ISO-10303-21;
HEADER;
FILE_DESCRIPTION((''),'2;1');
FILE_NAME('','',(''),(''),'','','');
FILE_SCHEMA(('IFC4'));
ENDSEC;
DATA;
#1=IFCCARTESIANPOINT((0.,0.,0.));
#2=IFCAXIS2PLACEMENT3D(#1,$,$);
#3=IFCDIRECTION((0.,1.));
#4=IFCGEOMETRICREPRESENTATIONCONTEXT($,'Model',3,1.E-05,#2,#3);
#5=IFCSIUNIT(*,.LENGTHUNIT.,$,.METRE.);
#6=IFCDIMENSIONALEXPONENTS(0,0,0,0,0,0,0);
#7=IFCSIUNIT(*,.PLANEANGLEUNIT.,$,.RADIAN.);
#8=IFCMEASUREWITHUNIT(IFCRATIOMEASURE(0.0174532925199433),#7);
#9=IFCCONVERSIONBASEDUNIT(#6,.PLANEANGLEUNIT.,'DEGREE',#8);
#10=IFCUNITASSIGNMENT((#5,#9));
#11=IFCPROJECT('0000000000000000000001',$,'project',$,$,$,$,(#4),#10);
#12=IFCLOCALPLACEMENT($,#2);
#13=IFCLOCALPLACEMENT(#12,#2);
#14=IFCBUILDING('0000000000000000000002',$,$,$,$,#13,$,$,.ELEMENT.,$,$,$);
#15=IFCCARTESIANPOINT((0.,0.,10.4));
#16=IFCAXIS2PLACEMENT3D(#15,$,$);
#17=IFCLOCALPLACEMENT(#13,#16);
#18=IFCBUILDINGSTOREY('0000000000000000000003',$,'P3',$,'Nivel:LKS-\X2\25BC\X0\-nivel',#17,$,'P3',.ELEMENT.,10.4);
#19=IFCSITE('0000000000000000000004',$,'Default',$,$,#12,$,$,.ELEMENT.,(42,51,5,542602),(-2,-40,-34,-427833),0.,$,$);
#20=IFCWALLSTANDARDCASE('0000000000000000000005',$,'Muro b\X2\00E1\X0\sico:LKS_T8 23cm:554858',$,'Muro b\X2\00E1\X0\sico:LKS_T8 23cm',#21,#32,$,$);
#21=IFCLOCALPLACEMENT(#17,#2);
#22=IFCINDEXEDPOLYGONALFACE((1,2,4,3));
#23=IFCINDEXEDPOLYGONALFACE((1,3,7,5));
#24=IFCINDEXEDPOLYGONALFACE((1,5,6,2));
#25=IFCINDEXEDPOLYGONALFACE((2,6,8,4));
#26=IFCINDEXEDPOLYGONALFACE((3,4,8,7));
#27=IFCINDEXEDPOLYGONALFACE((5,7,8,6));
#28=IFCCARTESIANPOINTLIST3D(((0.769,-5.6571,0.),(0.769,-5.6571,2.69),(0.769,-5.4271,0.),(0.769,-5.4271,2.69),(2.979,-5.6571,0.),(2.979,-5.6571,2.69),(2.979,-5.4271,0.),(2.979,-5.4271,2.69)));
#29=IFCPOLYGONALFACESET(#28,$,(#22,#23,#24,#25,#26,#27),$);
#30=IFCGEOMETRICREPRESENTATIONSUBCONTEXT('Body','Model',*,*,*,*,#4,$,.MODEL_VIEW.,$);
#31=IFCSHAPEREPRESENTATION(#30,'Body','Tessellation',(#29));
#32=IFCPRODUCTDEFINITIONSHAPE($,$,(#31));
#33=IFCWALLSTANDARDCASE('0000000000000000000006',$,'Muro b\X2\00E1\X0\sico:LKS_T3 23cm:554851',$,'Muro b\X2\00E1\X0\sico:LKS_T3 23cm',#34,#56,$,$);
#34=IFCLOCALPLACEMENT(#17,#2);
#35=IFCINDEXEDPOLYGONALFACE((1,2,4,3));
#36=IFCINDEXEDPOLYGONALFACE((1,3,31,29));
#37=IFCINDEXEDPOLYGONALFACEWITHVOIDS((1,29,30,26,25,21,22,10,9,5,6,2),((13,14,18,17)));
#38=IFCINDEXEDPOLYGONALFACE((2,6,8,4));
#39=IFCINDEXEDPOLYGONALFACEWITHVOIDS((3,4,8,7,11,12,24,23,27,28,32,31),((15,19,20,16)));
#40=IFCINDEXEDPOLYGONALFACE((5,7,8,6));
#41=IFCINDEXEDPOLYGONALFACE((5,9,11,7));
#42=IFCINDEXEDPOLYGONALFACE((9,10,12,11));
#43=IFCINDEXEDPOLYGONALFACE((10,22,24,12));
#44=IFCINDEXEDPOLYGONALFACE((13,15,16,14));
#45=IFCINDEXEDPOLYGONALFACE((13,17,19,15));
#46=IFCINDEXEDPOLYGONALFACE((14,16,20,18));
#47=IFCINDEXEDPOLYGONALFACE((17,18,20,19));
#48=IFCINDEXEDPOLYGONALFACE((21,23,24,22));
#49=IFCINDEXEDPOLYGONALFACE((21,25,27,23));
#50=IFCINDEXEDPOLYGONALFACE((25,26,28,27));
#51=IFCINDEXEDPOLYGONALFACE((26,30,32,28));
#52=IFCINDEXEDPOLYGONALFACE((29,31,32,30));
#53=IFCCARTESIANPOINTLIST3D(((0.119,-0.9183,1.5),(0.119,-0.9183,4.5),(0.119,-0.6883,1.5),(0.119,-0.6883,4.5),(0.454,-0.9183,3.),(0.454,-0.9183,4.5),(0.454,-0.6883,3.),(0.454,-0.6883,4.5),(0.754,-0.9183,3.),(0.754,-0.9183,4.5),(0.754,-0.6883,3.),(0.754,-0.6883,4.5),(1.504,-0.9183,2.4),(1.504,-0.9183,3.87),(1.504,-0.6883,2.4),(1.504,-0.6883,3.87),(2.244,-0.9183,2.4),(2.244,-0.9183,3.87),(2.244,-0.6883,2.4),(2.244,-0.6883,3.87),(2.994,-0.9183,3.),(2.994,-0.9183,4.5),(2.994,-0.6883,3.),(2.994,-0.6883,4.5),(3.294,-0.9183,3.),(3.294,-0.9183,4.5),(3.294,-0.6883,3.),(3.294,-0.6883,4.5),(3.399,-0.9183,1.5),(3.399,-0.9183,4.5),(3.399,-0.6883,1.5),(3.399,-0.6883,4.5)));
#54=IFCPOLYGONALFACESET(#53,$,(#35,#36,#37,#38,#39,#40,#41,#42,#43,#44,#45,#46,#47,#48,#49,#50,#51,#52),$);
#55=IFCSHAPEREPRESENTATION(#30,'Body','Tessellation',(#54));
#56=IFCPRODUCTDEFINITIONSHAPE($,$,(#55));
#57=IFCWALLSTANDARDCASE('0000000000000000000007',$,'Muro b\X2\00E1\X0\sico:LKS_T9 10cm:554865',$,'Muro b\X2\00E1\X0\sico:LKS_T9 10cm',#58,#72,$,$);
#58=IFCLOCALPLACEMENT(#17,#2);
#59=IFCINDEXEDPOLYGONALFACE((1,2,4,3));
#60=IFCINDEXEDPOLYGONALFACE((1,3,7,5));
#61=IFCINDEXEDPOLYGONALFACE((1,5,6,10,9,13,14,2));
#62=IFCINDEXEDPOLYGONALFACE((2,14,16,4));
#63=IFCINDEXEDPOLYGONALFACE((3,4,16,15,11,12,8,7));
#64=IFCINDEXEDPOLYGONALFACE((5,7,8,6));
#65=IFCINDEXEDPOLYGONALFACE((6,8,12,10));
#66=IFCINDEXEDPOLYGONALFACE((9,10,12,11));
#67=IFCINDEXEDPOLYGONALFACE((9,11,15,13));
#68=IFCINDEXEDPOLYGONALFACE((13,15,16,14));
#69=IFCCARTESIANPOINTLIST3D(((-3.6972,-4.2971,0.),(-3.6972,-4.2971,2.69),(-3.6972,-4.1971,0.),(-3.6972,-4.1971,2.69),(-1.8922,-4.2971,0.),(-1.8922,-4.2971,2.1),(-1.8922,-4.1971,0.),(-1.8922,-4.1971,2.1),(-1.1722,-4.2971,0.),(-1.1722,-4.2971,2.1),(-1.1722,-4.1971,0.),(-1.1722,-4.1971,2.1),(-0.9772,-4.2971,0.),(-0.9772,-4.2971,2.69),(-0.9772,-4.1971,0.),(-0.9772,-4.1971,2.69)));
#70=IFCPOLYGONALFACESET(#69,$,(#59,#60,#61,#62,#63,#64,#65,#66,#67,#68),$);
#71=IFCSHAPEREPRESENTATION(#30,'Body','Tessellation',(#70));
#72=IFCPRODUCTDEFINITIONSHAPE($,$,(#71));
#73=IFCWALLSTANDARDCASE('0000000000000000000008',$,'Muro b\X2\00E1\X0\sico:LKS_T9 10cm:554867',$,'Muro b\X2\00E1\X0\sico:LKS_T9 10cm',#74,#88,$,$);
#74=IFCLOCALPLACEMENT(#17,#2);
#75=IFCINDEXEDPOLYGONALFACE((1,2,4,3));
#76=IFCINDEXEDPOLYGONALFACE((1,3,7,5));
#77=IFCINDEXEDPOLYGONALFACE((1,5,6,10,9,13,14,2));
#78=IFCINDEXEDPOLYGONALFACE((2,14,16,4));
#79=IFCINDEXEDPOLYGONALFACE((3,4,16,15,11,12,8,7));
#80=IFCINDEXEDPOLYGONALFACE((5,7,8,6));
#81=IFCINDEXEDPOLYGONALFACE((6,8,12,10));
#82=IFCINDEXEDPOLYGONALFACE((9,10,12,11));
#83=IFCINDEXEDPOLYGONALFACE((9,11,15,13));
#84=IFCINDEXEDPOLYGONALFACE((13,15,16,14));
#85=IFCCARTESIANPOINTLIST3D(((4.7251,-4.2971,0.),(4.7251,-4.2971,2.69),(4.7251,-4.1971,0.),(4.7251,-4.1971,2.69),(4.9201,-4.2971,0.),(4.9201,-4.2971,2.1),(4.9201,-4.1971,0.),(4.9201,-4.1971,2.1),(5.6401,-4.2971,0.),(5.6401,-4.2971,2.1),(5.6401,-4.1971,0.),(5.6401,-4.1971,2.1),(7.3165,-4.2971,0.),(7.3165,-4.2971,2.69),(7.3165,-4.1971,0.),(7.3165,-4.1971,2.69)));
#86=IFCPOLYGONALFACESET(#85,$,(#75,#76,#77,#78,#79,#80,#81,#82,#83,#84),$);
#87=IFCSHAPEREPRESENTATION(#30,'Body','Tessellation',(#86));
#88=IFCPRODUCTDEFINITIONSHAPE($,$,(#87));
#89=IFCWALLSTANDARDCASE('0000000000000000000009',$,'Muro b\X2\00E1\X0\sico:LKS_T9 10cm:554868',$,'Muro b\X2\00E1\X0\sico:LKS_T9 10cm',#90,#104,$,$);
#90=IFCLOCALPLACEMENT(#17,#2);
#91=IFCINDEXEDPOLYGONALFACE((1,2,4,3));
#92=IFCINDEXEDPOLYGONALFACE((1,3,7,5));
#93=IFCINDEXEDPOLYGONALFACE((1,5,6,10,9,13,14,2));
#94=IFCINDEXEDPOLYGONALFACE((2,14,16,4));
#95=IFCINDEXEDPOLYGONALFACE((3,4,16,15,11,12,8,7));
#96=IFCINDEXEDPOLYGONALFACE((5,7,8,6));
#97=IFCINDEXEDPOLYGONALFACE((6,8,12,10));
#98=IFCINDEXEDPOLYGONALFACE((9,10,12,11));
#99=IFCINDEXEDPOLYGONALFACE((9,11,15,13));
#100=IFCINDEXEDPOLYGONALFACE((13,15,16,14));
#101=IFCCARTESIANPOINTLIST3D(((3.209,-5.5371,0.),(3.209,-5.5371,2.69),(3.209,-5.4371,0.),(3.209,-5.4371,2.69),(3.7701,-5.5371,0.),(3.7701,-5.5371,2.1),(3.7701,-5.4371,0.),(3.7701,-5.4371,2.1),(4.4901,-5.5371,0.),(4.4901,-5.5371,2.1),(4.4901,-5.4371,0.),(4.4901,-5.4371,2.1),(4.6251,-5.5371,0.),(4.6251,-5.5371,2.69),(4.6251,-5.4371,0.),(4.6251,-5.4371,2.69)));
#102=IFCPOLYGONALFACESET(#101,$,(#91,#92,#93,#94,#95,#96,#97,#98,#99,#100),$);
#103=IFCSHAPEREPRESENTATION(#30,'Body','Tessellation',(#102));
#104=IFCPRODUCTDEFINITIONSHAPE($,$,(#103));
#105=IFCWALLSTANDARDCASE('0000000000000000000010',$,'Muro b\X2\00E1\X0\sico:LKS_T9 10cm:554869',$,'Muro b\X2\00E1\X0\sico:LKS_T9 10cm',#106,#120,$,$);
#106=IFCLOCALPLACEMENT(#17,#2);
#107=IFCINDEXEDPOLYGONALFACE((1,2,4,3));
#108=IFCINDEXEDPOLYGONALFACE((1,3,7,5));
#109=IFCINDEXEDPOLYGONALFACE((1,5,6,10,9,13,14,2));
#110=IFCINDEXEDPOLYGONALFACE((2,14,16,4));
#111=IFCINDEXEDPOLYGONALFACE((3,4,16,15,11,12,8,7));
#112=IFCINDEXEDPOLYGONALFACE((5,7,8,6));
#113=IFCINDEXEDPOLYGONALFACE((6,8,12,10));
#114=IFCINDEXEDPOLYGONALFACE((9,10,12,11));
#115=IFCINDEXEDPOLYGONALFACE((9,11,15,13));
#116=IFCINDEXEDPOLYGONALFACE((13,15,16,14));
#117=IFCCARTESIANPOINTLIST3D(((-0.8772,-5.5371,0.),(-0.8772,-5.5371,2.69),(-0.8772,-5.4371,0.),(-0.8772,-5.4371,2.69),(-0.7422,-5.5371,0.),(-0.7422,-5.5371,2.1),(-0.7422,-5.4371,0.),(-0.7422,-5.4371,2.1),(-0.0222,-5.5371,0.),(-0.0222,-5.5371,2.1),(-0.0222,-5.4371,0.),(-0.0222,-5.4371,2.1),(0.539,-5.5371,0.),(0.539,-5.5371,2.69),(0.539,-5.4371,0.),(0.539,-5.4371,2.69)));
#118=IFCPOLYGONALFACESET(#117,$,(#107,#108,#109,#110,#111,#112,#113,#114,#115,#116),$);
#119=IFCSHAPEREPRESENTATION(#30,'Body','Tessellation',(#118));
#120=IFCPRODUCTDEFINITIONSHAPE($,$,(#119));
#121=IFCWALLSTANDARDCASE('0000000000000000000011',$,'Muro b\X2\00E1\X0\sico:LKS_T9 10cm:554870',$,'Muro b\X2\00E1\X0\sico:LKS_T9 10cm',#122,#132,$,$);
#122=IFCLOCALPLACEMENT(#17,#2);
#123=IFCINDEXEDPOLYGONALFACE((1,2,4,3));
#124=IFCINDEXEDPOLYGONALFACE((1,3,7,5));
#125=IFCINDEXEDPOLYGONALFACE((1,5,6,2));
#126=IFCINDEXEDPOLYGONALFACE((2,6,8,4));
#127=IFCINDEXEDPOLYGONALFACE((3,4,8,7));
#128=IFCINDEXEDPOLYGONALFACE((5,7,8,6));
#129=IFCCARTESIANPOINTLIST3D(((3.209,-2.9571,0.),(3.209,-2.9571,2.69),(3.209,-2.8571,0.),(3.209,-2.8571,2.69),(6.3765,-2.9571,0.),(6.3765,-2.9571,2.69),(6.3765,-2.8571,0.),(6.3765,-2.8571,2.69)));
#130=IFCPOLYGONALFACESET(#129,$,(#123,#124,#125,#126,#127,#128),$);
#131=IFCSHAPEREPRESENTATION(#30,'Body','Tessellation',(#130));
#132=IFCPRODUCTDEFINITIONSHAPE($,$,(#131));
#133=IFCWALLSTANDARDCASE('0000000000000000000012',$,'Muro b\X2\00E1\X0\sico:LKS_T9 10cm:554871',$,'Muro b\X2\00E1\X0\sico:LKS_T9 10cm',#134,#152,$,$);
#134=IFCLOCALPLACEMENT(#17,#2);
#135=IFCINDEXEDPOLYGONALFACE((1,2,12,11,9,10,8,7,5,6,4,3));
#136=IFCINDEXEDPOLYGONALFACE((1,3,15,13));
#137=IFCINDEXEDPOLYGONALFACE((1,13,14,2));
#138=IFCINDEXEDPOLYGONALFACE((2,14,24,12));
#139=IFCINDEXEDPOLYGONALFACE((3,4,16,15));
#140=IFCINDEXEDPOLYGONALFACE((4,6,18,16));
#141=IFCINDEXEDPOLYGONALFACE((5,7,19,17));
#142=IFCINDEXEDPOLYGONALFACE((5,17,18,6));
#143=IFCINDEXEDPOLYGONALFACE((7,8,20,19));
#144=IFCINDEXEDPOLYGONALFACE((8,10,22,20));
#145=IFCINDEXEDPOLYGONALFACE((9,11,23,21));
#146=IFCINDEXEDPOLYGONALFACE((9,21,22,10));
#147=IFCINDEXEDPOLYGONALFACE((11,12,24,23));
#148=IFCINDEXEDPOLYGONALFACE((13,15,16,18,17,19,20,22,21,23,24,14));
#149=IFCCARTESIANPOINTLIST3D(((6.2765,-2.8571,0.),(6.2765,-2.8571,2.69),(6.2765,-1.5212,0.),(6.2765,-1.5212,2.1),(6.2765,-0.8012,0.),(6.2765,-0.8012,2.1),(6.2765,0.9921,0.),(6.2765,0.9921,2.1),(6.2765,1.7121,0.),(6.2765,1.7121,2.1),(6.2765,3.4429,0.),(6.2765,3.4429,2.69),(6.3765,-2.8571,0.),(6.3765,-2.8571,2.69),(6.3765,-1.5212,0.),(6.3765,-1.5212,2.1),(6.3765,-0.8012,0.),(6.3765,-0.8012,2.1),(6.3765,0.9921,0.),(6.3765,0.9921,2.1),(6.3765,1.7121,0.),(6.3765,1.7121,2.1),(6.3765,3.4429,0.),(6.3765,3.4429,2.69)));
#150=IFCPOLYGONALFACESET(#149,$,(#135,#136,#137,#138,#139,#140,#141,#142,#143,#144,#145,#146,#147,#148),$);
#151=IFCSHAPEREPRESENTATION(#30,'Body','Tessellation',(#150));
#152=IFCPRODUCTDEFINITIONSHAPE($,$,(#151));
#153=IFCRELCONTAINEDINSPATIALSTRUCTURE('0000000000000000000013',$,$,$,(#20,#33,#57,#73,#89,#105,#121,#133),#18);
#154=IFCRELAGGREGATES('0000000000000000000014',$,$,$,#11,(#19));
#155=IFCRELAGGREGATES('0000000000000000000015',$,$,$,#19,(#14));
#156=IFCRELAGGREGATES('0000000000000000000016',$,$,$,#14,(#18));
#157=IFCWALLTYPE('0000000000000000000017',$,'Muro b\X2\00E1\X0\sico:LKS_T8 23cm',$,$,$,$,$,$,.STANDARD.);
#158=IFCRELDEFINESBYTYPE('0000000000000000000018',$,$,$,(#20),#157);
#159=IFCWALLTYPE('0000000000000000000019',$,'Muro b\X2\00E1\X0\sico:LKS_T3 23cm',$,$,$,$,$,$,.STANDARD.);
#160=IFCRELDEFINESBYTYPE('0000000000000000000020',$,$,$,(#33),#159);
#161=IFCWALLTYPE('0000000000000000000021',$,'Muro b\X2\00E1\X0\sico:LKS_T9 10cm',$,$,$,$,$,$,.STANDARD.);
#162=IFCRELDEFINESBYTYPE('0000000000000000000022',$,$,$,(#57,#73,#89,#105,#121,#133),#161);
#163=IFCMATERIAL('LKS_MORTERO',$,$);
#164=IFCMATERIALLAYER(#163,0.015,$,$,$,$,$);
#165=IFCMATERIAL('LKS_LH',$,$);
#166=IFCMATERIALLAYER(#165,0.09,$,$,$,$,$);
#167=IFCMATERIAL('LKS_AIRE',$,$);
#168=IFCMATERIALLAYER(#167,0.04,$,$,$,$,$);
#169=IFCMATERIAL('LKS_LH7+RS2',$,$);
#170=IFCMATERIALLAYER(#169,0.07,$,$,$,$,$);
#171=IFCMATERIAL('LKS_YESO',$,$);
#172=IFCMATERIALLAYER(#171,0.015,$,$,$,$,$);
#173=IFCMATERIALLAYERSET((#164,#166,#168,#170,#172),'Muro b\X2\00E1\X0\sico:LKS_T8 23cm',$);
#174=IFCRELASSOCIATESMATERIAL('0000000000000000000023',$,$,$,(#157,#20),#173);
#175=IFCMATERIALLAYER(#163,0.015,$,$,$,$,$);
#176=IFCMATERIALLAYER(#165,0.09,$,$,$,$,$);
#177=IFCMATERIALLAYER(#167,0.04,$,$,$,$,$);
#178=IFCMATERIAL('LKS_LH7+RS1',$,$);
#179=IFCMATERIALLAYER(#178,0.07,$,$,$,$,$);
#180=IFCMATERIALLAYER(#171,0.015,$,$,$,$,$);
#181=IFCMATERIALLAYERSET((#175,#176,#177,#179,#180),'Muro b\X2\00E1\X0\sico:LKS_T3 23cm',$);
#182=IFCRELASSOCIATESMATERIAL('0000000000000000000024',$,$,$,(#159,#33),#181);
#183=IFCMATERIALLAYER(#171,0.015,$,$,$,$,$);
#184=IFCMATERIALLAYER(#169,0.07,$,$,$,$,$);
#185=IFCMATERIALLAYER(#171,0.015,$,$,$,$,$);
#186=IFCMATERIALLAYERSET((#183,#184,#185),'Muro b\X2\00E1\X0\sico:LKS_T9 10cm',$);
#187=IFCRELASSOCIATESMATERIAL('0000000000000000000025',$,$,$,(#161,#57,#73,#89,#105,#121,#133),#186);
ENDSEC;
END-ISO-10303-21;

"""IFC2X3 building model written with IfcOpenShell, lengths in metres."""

from ifc_helpers import new_model, entity, si_unit, converted_unit, direction, frame, frame_2d, origin, place, context, subcontext, project, spatial, polyline, rectangle, extrude, clip, bounded_halfspace, material, layer, layer_set, layer_usage, type_object, element, save


model = new_model("IFC2X3")

# Units and contexts
model_context = context("Model", 3, precision=1e-05, world=origin(), true_north=direction((0.0, 1.0)))
body_context = subcontext(model_context, "Body", "Model", "MODEL_VIEW")
ifc_project = project(units=[si_unit("LENGTHUNIT", "METRE"), converted_unit("PLANEANGLEUNIT", "DEGREE", entity("IfcRatioMeasure", 0.0174532925199433), si_unit("PLANEANGLEUNIT", "RADIAN"), dimensions=[0, 0, 0, 0, 0, 0, 0])], contexts=[model_context])

# Site, building, storey
site_placement = place(None, origin())
site = spatial("IfcSite", under=ifc_project, at=site_placement, Name="Default", CompositionType="ELEMENT", RefLatitude=(42, 51, 5, 542602), RefLongitude=(-2, -40, -34, -427833), RefElevation=0.0)
building_placement = place(site_placement, origin())
building = spatial("IfcBuilding", under=site, at=building_placement, CompositionType="ELEMENT")
storey_placement = place(building_placement, frame((0.0, 0.0, 10.4)))
storey = spatial("IfcBuildingStorey", under=building, at=storey_placement, Name="P3", ObjectType="Nivel:LKS-▼-nivel", LongName="P3", CompositionType="ELEMENT", Elevation=10.4)

# Wall
ifc_material_1 = material(Name="LKS_MORTERO")
ifc_layer_1 = layer(ifc_material_1, 0.015)
ifc_material_2 = material(Name="LKS_LH")
ifc_layer_2 = layer(ifc_material_2, 0.09)
ifc_material_3 = material(Name="LKS_AIRE")
ifc_layer_3 = layer(ifc_material_3, 0.04)
ifc_material_4 = material(Name="LKS_LH7+RS2")
ifc_layer_4 = layer(ifc_material_4, 0.07)
ifc_material_5 = material(Name="LKS_YESO")
ifc_layer_5 = layer(ifc_material_5, 0.015)
ifc_layer_set_1 = layer_set([ifc_layer_1, ifc_layer_2, ifc_layer_3, ifc_layer_4, ifc_layer_5], Name="Muro básico:LKS_T8 23cm")
ifc_layer_usage_1 = layer_usage(ifc_layer_set_1, "AXIS2", "POSITIVE", -0.115)
wall_type_1 = type_object("IfcWallType", Name="Muro básico:LKS_T8 23cm", PredefinedType="STANDARD", material=ifc_layer_set_1)
wall_1_placement = place(storey_placement, frame((2.979, -5.5421, 0.0), z_axis=(0.0, 0.0, 1.0), x_axis=(-1.0, 0.0, 0.0)))
element("IfcWallStandardCase", 1, at=wall_1_placement, inside=storey, type_object=wall_type_1, material=ifc_layer_usage_1, Name="Muro básico:LKS_T8 23cm:554858", ObjectType="Muro básico:LKS_T8 23cm", context=body_context, shape_type="SweptSolid", body=[
    extrude(rectangle(XDim=2.21, YDim=0.23, at=frame_2d((1.105, 0.0), x_axis=(-1.0, 0.0))), origin(), (0.0, 0.0, 1.0), 2.69),
])

# Walls, openings
ifc_layer_6 = layer(ifc_material_1, 0.015)
ifc_layer_7 = layer(ifc_material_2, 0.09)
ifc_layer_8 = layer(ifc_material_3, 0.04)
ifc_material_6 = material(Name="LKS_LH7+RS1")
ifc_layer_9 = layer(ifc_material_6, 0.07)
ifc_layer_10 = layer(ifc_material_5, 0.015)
ifc_layer_set_2 = layer_set([ifc_layer_6, ifc_layer_7, ifc_layer_8, ifc_layer_9, ifc_layer_10], Name="Muro básico:LKS_T3 23cm")
ifc_layer_usage_2 = layer_usage(ifc_layer_set_2, "AXIS2", "NEGATIVE", 0.115)
wall_type_2 = type_object("IfcWallType", Name="Muro básico:LKS_T3 23cm", PredefinedType="STANDARD", material=ifc_layer_set_2)
wall_2_placement = place(storey_placement, frame((3.629, -0.8033, 1.5), z_axis=(0.0, 0.0, 1.0), x_axis=(-1.0, 0.0, 0.0)))
wall_2 = element("IfcWallStandardCase", 2, at=wall_2_placement, inside=storey, type_object=wall_type_2, material=ifc_layer_usage_2, Name="Muro básico:LKS_T3 23cm:554851", ObjectType="Muro básico:LKS_T3 23cm", context=body_context, shape_type="Clipping", body=[
    clip(clip(extrude(rectangle(XDim=3.28, YDim=0.23, at=frame_2d((1.87, 0.0), x_axis=(-1.0, 0.0))), origin(), (0.0, 0.0, 1.0), 3.0), bounded_halfspace(frame((0.635, -0.115, 1.5), z_axis=(0.0, 0.0, -1.0), x_axis=(-1.0, 0.0, 0.0)), True, frame((0.635, -0.115, 1.5), z_axis=(0.0, 0.0, -1.0), x_axis=(-1.0, 0.0, 0.0)), polyline([(0.0, 0.0), (0.3, 0.0), (0.3, 0.23), (0.0, 0.23), (0.0, 0.0)]))), bounded_halfspace(frame((3.175, -0.115, 1.5), z_axis=(0.0, 0.0, -1.0), x_axis=(-1.0, 0.0, 0.0)), True, frame((3.175, -0.115, 1.5), z_axis=(0.0, 0.0, -1.0), x_axis=(-1.0, 0.0, 0.0)), polyline([(0.0, 0.0), (0.3, 0.0), (0.3, 0.23), (0.0, 0.23), (0.0, 0.0)]))),
])
opening_1_placement = place(wall_2_placement, frame((2.125, 0.115, 0.9)))
element("IfcOpeningElement", 3, at=opening_1_placement, cuts=wall_2, ObjectType="Opening", context=body_context, shape_type="SweptSolid", body=[
    extrude(rectangle(XDim=1.47, YDim=0.74, at=frame_2d((0.735, 0.37), x_axis=(1.0, 0.0))), frame((0.0, 0.0, 0.0), z_axis=(0.0, -1.0, 0.0), x_axis=(0.0, 0.0, 1.0)), (0.0, 0.0, 1.0), 0.23),
])
ifc_layer_11 = layer(ifc_material_5, 0.015)
ifc_layer_12 = layer(ifc_material_4, 0.07)
ifc_layer_13 = layer(ifc_material_5, 0.015)
ifc_layer_set_3 = layer_set([ifc_layer_11, ifc_layer_12, ifc_layer_13], Name="Muro básico:LKS_T9 10cm")
ifc_layer_usage_3 = layer_usage(ifc_layer_set_3, "AXIS2", "POSITIVE", -0.05)
wall_type_3 = type_object("IfcWallType", Name="Muro básico:LKS_T9 10cm", PredefinedType="STANDARD", material=ifc_layer_set_3)
wall_3_placement = place(storey_placement, frame((-0.9772, -4.2471, 0.0), z_axis=(0.0, 0.0, 1.0), x_axis=(-1.0, 0.0, 0.0)))
wall_3 = element("IfcWallStandardCase", 4, at=wall_3_placement, inside=storey, type_object=wall_type_3, material=ifc_layer_usage_3, Name="Muro básico:LKS_T9 10cm:554865", ObjectType="Muro básico:LKS_T9 10cm", context=body_context, shape_type="SweptSolid", body=[
    extrude(rectangle(XDim=2.72, YDim=0.1, at=frame_2d((1.36, 0.0), x_axis=(-1.0, 0.0))), origin(), (0.0, 0.0, 1.0), 2.69),
])
opening_2_placement = place(wall_3_placement, frame((0.195, -0.05, 0.0)))
element("IfcOpeningElement", 5, at=opening_2_placement, cuts=wall_3, ObjectType="Opening", context=body_context, shape_type="SweptSolid", body=[
    extrude(rectangle(XDim=2.1, YDim=0.72, at=frame_2d((1.05, 0.36), x_axis=(1.0, 0.0))), frame((0.0, 0.0, 0.0), z_axis=(0.0, 1.0, 0.0), x_axis=(0.0, 0.0, 1.0)), (0.0, 0.0, 1.0), 0.1),
])
ifc_layer_usage_4 = layer_usage(ifc_layer_set_3, "AXIS2", "NEGATIVE", 0.05)
wall_4_placement = place(storey_placement, frame((4.7251, -4.2471, 0.0)))
wall_4 = element("IfcWallStandardCase", 6, at=wall_4_placement, inside=storey, type_object=wall_type_3, material=ifc_layer_usage_4, Name="Muro básico:LKS_T9 10cm:554867", ObjectType="Muro básico:LKS_T9 10cm", context=body_context, shape_type="Clipping", body=[
    clip(extrude(rectangle(XDim=2.5915, YDim=0.1, at=frame_2d((1.2957, 0.0), x_axis=(-1.0, 0.0))), origin(), (0.0, 0.0, 1.0), 2.69), bounded_halfspace(frame((2.5915, -0.05, 2.69), z_axis=(-1.0, 0.0, 0.0), x_axis=(0.0, 0.0, -1.0)), True, frame((2.5915, -0.05, 2.69), z_axis=(-1.0, 0.0, 0.0), x_axis=(0.0, 0.0, -1.0)), polyline([(0.0, 0.0), (0.0, -0.1), (2.69, -0.1), (2.69, 0.0), (0.0, 0.0)]))),
])
opening_3_placement = place(wall_4_placement, frame((0.915, 0.05, 0.0)))
element("IfcOpeningElement", 7, at=opening_3_placement, cuts=wall_4, ObjectType="Opening", context=body_context, shape_type="SweptSolid", body=[
    extrude(rectangle(XDim=2.1, YDim=0.72, at=frame_2d((1.05, 0.36), x_axis=(1.0, 0.0))), frame((0.0, 0.0, 0.0), z_axis=(0.0, -1.0, 0.0), x_axis=(0.0, 0.0, 1.0)), (0.0, 0.0, 1.0), 0.1),
])
ifc_layer_usage_5 = layer_usage(ifc_layer_set_3, "AXIS2", "POSITIVE", -0.05)
wall_5_placement = place(storey_placement, frame((3.209, -5.4871, 0.0)))
wall_5 = element("IfcWallStandardCase", 8, at=wall_5_placement, inside=storey, type_object=wall_type_3, material=ifc_layer_usage_5, Name="Muro básico:LKS_T9 10cm:554868", ObjectType="Muro básico:LKS_T9 10cm", context=body_context, shape_type="SweptSolid", body=[
    extrude(rectangle(XDim=1.4161, YDim=0.1, at=frame_2d((0.7081, 0.0), x_axis=(-1.0, 0.0))), origin(), (0.0, 0.0, 1.0), 2.69),
])
opening_4_placement = place(wall_5_placement, frame((1.2811, 0.05, 0.0)))
element("IfcOpeningElement", 9, at=opening_4_placement, cuts=wall_5, ObjectType="Opening", context=body_context, shape_type="SweptSolid", body=[
    extrude(rectangle(XDim=2.1, YDim=0.72, at=frame_2d((1.05, 0.36), x_axis=(1.0, 0.0))), frame((0.0, 0.0, 0.0), z_axis=(0.0, -1.0, 0.0), x_axis=(0.0, 0.0, 1.0)), (0.0, 0.0, 1.0), 0.1),
])
ifc_layer_usage_6 = layer_usage(ifc_layer_set_3, "AXIS2", "NEGATIVE", 0.05)
wall_6_placement = place(storey_placement, frame((0.539, -5.4871, 0.0), z_axis=(0.0, 0.0, 1.0), x_axis=(-1.0, 0.0, 0.0)))
wall_6 = element("IfcWallStandardCase", 10, at=wall_6_placement, inside=storey, type_object=wall_type_3, material=ifc_layer_usage_6, Name="Muro básico:LKS_T9 10cm:554869", ObjectType="Muro básico:LKS_T9 10cm", context=body_context, shape_type="SweptSolid", body=[
    extrude(rectangle(XDim=1.4161, YDim=0.1, at=frame_2d((0.7081, 0.0), x_axis=(-1.0, 0.0))), origin(), (0.0, 0.0, 1.0), 2.69),
])
opening_5_placement = place(wall_6_placement, frame((0.5611, -0.05, 0.0)))
element("IfcOpeningElement", 11, at=opening_5_placement, cuts=wall_6, ObjectType="Opening", context=body_context, shape_type="SweptSolid", body=[
    extrude(rectangle(XDim=2.1, YDim=0.72, at=frame_2d((1.05, 0.36), x_axis=(1.0, 0.0))), frame((0.0, 0.0, 0.0), z_axis=(0.0, 1.0, 0.0), x_axis=(0.0, 0.0, 1.0)), (0.0, 0.0, 1.0), 0.1),
])

# Wall
ifc_layer_usage_7 = layer_usage(ifc_layer_set_3, "AXIS2", "NEGATIVE", 0.05)
wall_7_placement = place(storey_placement, frame((3.209, -2.9071, 0.0)))
element("IfcWallStandardCase", 12, at=wall_7_placement, inside=storey, type_object=wall_type_3, material=ifc_layer_usage_7, Name="Muro básico:LKS_T9 10cm:554870", ObjectType="Muro básico:LKS_T9 10cm", context=body_context, shape_type="SweptSolid", body=[
    extrude(rectangle(XDim=3.1676, YDim=0.1, at=frame_2d((1.5838, 0.0), x_axis=(-1.0, 0.0))), origin(), (0.0, 0.0, 1.0), 2.69),
])

# Wall, openings
ifc_layer_usage_8 = layer_usage(ifc_layer_set_3, "AXIS2", "NEGATIVE", 0.05)
wall_8_placement = place(storey_placement, frame((6.3265, -2.8571, 0.0), z_axis=(0.0, 0.0, 1.0), x_axis=(0.0, 1.0, 0.0)))
wall_8 = element("IfcWallStandardCase", 13, at=wall_8_placement, inside=storey, type_object=wall_type_3, material=ifc_layer_usage_8, Name="Muro básico:LKS_T9 10cm:554871", ObjectType="Muro básico:LKS_T9 10cm", context=body_context, shape_type="SweptSolid", body=[
    extrude(rectangle(XDim=6.3, YDim=0.1, at=frame_2d((3.15, 0.0), x_axis=(-1.0, 0.0))), origin(), (0.0, 0.0, 1.0), 2.69),
])
opening_6_placement = place(wall_8_placement, frame((1.3359, -0.05, 0.0)))
element("IfcOpeningElement", 14, at=opening_6_placement, cuts=wall_8, ObjectType="Opening", context=body_context, shape_type="SweptSolid", body=[
    extrude(rectangle(XDim=2.1, YDim=0.72, at=frame_2d((1.05, 0.36), x_axis=(1.0, 0.0))), frame((0.0, 0.0, 0.0), z_axis=(0.0, 1.0, 0.0), x_axis=(0.0, 0.0, 1.0)), (0.0, 0.0, 1.0), 0.1),
])
opening_7_placement = place(wall_8_placement, frame((3.8492, -0.05, 0.0)))
element("IfcOpeningElement", 15, at=opening_7_placement, cuts=wall_8, ObjectType="Opening", context=body_context, shape_type="SweptSolid", body=[
    extrude(rectangle(XDim=2.1, YDim=0.72, at=frame_2d((1.05, 0.36), x_axis=(1.0, 0.0))), frame((0.0, 0.0, 0.0), z_axis=(0.0, 1.0, 0.0), x_axis=(0.0, 0.0, 1.0)), (0.0, 0.0, 1.0), 0.1),
])

save(model, "model.ifc")
